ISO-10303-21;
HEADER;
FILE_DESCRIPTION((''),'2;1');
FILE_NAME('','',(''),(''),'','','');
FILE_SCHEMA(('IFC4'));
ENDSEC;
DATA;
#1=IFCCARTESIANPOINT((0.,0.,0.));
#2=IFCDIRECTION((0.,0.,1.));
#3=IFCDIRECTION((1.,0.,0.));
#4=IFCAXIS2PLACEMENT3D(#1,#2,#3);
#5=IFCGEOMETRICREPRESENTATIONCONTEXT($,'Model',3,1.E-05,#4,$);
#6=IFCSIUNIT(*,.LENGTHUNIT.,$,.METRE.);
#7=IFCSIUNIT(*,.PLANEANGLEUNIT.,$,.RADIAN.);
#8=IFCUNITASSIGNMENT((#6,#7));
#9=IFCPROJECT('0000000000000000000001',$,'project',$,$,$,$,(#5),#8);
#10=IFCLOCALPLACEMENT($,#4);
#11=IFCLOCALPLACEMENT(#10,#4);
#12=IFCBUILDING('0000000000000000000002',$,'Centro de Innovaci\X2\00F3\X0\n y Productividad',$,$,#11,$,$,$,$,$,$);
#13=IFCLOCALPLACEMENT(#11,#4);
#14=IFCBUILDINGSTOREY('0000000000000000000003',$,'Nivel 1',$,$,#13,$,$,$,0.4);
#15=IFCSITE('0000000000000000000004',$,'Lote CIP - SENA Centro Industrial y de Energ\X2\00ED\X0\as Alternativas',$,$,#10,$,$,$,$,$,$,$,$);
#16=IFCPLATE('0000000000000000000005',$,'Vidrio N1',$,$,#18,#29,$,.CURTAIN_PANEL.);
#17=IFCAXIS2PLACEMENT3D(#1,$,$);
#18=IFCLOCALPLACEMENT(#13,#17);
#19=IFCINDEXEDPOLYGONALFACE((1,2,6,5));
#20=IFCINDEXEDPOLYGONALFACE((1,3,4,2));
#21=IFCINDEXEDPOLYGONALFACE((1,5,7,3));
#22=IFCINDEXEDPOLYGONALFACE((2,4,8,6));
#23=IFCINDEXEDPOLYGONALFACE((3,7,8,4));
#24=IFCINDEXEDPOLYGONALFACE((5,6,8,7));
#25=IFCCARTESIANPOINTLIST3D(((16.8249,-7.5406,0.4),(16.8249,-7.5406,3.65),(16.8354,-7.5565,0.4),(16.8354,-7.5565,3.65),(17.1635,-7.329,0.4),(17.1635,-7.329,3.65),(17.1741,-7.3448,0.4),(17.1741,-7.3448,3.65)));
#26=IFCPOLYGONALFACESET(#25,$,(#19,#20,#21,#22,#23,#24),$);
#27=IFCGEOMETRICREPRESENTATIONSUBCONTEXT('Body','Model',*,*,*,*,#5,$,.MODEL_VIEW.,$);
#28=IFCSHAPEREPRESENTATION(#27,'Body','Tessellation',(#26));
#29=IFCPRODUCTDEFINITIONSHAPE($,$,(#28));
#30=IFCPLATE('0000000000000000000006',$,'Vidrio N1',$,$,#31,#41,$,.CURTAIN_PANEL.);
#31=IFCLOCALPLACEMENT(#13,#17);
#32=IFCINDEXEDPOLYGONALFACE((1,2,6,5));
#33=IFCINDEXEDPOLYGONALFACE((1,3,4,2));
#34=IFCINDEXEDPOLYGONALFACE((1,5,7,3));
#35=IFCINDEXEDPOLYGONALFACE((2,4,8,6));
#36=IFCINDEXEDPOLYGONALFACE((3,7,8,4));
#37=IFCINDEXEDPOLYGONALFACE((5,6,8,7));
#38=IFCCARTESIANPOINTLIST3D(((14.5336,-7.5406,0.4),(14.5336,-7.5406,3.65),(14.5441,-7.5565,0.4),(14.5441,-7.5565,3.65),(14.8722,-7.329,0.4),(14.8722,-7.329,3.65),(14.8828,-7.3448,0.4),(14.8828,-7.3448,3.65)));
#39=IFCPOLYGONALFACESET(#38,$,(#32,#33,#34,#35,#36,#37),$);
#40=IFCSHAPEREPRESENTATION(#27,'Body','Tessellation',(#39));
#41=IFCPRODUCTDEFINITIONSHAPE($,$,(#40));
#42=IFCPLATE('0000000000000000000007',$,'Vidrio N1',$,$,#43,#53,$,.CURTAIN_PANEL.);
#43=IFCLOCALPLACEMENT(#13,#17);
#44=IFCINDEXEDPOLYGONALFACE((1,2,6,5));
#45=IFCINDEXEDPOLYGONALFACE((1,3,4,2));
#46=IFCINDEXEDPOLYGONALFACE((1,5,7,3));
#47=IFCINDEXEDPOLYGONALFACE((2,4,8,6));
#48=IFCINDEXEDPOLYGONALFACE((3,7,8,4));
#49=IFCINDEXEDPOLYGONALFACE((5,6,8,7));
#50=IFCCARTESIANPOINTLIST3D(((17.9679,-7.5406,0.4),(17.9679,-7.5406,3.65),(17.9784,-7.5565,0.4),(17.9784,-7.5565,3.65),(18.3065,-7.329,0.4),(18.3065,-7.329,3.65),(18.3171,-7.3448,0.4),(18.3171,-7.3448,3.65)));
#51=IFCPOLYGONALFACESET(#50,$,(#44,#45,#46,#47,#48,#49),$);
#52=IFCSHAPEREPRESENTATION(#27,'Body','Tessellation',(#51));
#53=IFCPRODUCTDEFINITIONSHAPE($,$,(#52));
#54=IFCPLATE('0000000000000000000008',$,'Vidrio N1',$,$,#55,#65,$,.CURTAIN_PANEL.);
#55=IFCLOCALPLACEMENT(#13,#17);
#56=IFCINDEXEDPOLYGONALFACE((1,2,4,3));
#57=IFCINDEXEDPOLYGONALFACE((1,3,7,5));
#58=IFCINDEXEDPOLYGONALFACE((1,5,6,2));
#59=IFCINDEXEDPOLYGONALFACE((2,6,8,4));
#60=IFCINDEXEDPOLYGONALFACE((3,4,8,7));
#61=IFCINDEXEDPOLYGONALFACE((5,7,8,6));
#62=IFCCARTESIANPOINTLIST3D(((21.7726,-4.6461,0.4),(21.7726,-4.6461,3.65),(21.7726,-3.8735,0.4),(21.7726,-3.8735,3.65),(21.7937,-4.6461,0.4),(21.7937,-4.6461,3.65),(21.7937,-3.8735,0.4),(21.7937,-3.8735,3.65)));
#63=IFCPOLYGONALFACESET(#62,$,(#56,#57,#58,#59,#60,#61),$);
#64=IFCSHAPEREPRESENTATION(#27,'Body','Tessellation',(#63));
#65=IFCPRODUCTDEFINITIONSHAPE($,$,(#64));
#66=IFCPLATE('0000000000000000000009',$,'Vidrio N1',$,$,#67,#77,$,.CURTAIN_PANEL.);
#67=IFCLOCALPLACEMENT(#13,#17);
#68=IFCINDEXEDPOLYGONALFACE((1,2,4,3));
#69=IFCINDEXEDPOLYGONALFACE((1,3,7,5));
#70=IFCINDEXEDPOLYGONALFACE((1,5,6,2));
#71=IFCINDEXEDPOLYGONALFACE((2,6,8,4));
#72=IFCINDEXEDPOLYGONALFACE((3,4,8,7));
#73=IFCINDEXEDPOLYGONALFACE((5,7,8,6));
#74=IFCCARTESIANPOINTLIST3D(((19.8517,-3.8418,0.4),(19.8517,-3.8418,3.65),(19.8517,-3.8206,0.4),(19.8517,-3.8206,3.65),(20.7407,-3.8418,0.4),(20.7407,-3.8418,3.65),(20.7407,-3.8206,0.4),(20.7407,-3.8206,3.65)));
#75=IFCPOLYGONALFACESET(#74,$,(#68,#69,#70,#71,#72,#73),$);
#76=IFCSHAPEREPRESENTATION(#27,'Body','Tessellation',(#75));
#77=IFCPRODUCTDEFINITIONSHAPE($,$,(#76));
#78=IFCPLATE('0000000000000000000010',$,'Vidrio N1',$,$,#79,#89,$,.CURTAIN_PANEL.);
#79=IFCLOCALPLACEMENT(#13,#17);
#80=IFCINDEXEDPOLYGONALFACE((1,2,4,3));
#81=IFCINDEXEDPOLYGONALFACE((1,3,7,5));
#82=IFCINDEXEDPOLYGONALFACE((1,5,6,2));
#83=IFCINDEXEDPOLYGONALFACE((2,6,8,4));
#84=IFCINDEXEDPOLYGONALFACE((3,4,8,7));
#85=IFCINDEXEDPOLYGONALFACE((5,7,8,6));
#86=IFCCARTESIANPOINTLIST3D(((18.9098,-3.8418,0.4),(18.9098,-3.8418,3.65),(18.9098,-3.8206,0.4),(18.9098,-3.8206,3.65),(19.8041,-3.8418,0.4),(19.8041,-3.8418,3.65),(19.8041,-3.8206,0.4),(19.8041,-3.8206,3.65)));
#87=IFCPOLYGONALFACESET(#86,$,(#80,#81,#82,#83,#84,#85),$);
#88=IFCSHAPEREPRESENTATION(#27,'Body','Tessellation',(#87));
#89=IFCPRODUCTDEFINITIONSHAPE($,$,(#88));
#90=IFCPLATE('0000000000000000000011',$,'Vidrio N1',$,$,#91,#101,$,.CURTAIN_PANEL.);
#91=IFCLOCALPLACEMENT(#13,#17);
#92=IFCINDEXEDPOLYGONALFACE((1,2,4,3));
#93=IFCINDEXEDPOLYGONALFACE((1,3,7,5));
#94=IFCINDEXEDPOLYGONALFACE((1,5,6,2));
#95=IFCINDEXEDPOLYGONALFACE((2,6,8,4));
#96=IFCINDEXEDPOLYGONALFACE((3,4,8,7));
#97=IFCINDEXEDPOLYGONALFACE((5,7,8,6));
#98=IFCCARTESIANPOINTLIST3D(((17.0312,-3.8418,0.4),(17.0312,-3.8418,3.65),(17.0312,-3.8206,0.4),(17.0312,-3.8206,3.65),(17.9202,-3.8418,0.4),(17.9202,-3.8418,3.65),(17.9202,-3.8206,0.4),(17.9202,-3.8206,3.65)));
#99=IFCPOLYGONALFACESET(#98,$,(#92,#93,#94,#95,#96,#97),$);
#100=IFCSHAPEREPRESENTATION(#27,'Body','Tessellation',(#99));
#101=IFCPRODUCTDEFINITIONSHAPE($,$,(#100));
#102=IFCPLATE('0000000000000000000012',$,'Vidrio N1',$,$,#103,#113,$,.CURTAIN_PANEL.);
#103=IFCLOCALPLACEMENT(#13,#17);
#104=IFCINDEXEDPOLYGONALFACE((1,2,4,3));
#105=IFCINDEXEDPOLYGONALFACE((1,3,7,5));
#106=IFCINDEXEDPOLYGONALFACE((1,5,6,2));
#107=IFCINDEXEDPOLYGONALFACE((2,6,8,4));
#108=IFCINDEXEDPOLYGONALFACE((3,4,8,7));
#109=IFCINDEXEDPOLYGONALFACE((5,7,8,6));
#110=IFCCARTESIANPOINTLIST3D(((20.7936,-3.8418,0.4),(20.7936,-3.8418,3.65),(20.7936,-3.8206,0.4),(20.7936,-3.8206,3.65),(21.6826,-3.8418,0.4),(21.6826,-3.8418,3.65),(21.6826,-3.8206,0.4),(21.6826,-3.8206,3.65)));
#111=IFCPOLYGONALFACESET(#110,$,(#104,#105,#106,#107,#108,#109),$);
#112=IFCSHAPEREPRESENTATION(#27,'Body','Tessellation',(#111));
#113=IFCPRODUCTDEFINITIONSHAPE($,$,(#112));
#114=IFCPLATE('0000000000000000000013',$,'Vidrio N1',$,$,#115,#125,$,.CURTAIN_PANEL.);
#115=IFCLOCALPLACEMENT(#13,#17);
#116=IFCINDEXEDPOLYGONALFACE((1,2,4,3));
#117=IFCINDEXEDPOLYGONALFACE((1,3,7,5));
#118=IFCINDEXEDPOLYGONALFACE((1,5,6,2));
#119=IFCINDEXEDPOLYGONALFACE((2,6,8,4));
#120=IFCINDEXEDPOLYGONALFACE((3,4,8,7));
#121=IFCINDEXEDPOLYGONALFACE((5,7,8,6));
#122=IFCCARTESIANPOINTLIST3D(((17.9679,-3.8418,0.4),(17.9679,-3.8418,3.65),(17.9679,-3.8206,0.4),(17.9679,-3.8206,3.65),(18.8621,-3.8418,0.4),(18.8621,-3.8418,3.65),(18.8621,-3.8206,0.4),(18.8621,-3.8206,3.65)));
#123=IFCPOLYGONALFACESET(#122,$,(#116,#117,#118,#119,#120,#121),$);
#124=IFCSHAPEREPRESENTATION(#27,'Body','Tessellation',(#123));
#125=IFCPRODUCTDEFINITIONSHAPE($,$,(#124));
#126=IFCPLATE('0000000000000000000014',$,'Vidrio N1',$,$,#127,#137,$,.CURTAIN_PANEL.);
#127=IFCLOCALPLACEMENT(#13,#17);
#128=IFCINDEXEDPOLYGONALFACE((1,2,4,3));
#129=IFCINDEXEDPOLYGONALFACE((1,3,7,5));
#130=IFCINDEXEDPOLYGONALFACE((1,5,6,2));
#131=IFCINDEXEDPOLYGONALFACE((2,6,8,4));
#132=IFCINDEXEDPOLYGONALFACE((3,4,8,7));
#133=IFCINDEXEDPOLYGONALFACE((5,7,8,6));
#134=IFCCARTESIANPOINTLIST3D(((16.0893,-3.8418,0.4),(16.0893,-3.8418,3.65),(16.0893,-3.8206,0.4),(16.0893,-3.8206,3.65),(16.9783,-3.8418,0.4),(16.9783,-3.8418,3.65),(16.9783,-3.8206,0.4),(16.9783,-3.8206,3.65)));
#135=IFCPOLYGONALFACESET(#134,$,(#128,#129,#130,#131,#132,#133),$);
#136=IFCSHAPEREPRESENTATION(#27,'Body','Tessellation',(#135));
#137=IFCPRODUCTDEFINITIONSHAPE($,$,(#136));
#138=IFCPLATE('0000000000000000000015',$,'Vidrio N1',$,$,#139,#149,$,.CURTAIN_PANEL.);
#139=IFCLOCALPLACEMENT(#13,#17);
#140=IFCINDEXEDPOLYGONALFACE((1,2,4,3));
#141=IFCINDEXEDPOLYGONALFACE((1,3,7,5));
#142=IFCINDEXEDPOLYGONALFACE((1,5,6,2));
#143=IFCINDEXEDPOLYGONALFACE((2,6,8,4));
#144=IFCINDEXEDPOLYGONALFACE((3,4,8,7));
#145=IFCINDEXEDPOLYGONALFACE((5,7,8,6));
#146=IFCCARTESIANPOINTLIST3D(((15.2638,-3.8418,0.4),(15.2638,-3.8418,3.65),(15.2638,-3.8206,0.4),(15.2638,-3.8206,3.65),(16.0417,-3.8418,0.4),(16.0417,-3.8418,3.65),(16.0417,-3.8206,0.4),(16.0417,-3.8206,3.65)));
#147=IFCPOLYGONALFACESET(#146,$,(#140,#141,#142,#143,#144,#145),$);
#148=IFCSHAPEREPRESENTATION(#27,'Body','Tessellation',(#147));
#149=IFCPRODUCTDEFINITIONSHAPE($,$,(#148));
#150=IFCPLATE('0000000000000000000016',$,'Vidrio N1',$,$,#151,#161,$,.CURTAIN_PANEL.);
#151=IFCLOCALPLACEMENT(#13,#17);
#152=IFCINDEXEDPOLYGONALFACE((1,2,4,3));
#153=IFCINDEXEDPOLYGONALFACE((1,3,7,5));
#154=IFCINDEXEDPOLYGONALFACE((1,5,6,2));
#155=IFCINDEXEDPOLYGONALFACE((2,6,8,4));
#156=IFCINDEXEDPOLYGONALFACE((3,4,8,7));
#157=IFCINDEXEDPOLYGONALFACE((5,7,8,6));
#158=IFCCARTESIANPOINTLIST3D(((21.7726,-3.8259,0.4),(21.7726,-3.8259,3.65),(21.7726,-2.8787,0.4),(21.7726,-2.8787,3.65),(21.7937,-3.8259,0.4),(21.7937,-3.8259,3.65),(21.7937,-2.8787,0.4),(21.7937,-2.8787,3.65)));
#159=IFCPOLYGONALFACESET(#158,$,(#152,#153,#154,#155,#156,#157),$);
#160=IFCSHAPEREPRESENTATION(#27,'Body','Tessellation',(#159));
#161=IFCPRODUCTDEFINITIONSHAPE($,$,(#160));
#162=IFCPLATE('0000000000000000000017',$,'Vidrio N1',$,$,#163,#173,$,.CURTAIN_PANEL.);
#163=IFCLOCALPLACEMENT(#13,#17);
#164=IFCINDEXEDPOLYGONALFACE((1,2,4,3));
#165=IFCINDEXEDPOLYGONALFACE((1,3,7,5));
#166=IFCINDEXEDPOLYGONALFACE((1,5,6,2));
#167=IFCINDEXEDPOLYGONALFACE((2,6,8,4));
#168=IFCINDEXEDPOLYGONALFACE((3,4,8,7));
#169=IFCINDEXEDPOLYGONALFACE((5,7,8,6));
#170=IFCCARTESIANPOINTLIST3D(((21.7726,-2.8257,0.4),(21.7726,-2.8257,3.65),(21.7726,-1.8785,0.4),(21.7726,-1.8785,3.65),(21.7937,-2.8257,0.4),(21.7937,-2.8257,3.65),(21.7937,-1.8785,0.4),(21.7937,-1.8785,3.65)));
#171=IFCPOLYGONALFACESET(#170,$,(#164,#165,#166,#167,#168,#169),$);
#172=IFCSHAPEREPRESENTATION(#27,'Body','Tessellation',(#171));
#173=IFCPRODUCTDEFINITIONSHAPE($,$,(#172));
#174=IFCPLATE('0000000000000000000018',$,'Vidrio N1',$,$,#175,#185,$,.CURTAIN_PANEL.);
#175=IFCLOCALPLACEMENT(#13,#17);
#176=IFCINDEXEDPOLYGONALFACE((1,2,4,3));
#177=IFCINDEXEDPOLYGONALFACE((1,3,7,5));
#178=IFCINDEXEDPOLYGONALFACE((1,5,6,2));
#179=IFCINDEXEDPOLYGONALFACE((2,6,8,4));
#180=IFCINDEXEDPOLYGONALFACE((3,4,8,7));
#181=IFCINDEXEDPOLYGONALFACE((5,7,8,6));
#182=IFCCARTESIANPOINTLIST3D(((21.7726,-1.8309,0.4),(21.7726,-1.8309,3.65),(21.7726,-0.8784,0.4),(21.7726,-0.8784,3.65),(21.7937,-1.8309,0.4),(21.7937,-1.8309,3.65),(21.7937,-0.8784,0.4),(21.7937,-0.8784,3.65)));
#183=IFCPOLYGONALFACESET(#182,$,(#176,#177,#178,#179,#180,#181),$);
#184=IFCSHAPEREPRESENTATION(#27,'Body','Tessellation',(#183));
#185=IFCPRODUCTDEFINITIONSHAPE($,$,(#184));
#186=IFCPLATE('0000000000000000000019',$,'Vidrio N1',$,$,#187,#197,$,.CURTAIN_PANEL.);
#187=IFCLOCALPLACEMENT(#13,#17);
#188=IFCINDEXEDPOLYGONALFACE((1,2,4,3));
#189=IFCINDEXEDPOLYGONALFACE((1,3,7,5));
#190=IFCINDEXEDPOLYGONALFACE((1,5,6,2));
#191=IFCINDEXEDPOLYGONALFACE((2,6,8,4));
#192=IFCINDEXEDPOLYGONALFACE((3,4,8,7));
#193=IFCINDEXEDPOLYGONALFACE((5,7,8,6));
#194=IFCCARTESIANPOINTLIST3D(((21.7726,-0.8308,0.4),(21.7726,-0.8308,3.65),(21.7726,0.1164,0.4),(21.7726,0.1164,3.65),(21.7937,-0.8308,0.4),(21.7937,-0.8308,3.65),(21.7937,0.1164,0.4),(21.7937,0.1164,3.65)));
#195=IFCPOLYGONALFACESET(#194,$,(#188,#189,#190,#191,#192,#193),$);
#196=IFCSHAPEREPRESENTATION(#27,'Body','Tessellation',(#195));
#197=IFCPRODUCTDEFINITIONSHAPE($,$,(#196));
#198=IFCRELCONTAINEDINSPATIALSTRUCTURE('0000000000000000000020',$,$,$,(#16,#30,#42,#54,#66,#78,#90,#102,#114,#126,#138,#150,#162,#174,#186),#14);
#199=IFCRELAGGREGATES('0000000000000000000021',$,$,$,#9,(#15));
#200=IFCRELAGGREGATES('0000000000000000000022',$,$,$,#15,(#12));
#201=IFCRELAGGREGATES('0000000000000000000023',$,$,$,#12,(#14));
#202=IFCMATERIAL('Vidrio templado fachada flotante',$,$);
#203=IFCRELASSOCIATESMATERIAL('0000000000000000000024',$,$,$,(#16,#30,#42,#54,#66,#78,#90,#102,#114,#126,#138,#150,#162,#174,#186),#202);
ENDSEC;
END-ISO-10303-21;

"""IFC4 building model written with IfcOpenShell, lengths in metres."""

from ifc_helpers import new_model, si_unit, frame, origin_with_axes, place, context, subcontext, project, spatial, polyline, outline, extrude, material, element, save


model = new_model("IFC4")

# Units and contexts
model_context = context("Model", 3, precision=1e-05, world=origin_with_axes())
body_context = subcontext(model_context, "Body", "Model", "MODEL_VIEW")
ifc_project = project(units=[si_unit("LENGTHUNIT", "METRE"), si_unit("PLANEANGLEUNIT", "RADIAN")], contexts=[model_context])

# Site, building, storey
site_placement = place(None, origin_with_axes())
site = spatial("IfcSite", under=ifc_project, at=site_placement, Name="Lote CIP - SENA Centro Industrial y de Energías Alternativas")
building_placement = place(site_placement, origin_with_axes())
building = spatial("IfcBuilding", under=site, at=building_placement, Name="Centro de Innovación y Productividad")
storey_placement = place(building_placement, origin_with_axes())
storey = spatial("IfcBuildingStorey", under=building, at=storey_placement, Name="Nivel 1", Elevation=0.4)

# Plates
ifc_material = material(Name="Vidrio templado fachada flotante")
plate_1_placement = place(storey_placement, origin_with_axes())
element("IfcPlate", 1, at=plate_1_placement, inside=storey, material=ifc_material, Name="Vidrio N1", PredefinedType="CURTAIN_PANEL", context=body_context, shape_type="SweptSolid", body=[
    extrude(outline(polyline([(17.1635, -7.329), (17.1741, -7.3448), (16.8354, -7.5565), (16.8249, -7.5406), (17.1635, -7.329)])), frame((0.0, 0.0, 0.4)), (0.0, 0.0, 1.0), 3.25),
])
plate_2_placement = place(storey_placement, origin_with_axes())
element("IfcPlate", 2, at=plate_2_placement, inside=storey, material=ifc_material, Name="Vidrio N1", PredefinedType="CURTAIN_PANEL", context=body_context, shape_type="SweptSolid", body=[
    extrude(outline(polyline([(14.8722, -7.329), (14.8828, -7.3448), (14.5441, -7.5565), (14.5336, -7.5406), (14.8722, -7.329)])), frame((0.0, 0.0, 0.4)), (0.0, 0.0, 1.0), 3.25),
])
plate_3_placement = place(storey_placement, origin_with_axes())
element("IfcPlate", 3, at=plate_3_placement, inside=storey, material=ifc_material, Name="Vidrio N1", PredefinedType="CURTAIN_PANEL", context=body_context, shape_type="SweptSolid", body=[
    extrude(outline(polyline([(18.3065, -7.329), (18.3171, -7.3448), (17.9784, -7.5565), (17.9679, -7.5406), (18.3065, -7.329)])), frame((0.0, 0.0, 0.4)), (0.0, 0.0, 1.0), 3.25),
])
plate_4_placement = place(storey_placement, origin_with_axes())
element("IfcPlate", 4, at=plate_4_placement, inside=storey, material=ifc_material, Name="Vidrio N1", PredefinedType="CURTAIN_PANEL", context=body_context, shape_type="SweptSolid", body=[
    extrude(outline(polyline([(21.7726, -3.8735), (21.7937, -3.8735), (21.7937, -4.6461), (21.7726, -4.6461), (21.7726, -3.8735)])), frame((0.0, 0.0, 0.4)), (0.0, 0.0, 1.0), 3.25),
])
plate_5_placement = place(storey_placement, origin_with_axes())
element("IfcPlate", 5, at=plate_5_placement, inside=storey, material=ifc_material, Name="Vidrio N1", PredefinedType="CURTAIN_PANEL", context=body_context, shape_type="SweptSolid", body=[
    extrude(outline(polyline([(20.7407, -3.8206), (20.7407, -3.8417), (19.8517, -3.8417), (19.8517, -3.8206), (20.7407, -3.8206)])), frame((0.0, 0.0, 0.4)), (0.0, 0.0, 1.0), 3.25),
])
plate_6_placement = place(storey_placement, origin_with_axes())
element("IfcPlate", 6, at=plate_6_placement, inside=storey, material=ifc_material, Name="Vidrio N1", PredefinedType="CURTAIN_PANEL", context=body_context, shape_type="SweptSolid", body=[
    extrude(outline(polyline([(18.9098, -3.8417), (18.9098, -3.8206), (19.8041, -3.8206), (19.8041, -3.8417), (18.9098, -3.8417)])), frame((0.0, 0.0, 0.4)), (0.0, 0.0, 1.0), 3.25),
])
plate_7_placement = place(storey_placement, origin_with_axes())
element("IfcPlate", 7, at=plate_7_placement, inside=storey, material=ifc_material, Name="Vidrio N1", PredefinedType="CURTAIN_PANEL", context=body_context, shape_type="SweptSolid", body=[
    extrude(outline(polyline([(17.0312, -3.8417), (17.0312, -3.8206), (17.9202, -3.8206), (17.9202, -3.8417), (17.0312, -3.8417)])), frame((0.0, 0.0, 0.4)), (0.0, 0.0, 1.0), 3.25),
])
plate_8_placement = place(storey_placement, origin_with_axes())
element("IfcPlate", 8, at=plate_8_placement, inside=storey, material=ifc_material, Name="Vidrio N1", PredefinedType="CURTAIN_PANEL", context=body_context, shape_type="SweptSolid", body=[
    extrude(outline(polyline([(21.6826, -3.8417), (20.7936, -3.8417), (20.7936, -3.8206), (21.6826, -3.8206), (21.6826, -3.8417)])), frame((0.0, 0.0, 0.4)), (0.0, 0.0, 1.0), 3.25),
])
plate_9_placement = place(storey_placement, origin_with_axes())
element("IfcPlate", 9, at=plate_9_placement, inside=storey, material=ifc_material, Name="Vidrio N1", PredefinedType="CURTAIN_PANEL", context=body_context, shape_type="SweptSolid", body=[
    extrude(outline(polyline([(18.8621, -3.8417), (17.9679, -3.8417), (17.9679, -3.8206), (18.8621, -3.8206), (18.8621, -3.8417)])), frame((0.0, 0.0, 0.4)), (0.0, 0.0, 1.0), 3.25),
])
plate_10_placement = place(storey_placement, origin_with_axes())
element("IfcPlate", 10, at=plate_10_placement, inside=storey, material=ifc_material, Name="Vidrio N1", PredefinedType="CURTAIN_PANEL", context=body_context, shape_type="SweptSolid", body=[
    extrude(outline(polyline([(16.9783, -3.8417), (16.0893, -3.8417), (16.0893, -3.8206), (16.9783, -3.8206), (16.9783, -3.8417)])), frame((0.0, 0.0, 0.4)), (0.0, 0.0, 1.0), 3.25),
])
plate_11_placement = place(storey_placement, origin_with_axes())
element("IfcPlate", 11, at=plate_11_placement, inside=storey, material=ifc_material, Name="Vidrio N1", PredefinedType="CURTAIN_PANEL", context=body_context, shape_type="SweptSolid", body=[
    extrude(outline(polyline([(15.2638, -3.8417), (15.2638, -3.8206), (16.0417, -3.8206), (16.0417, -3.8417), (15.2638, -3.8417)])), frame((0.0, 0.0, 0.4)), (0.0, 0.0, 1.0), 3.25),
])
plate_12_placement = place(storey_placement, origin_with_axes())
element("IfcPlate", 12, at=plate_12_placement, inside=storey, material=ifc_material, Name="Vidrio N1", PredefinedType="CURTAIN_PANEL", context=body_context, shape_type="SweptSolid", body=[
    extrude(outline(polyline([(21.7726, -2.8787), (21.7937, -2.8787), (21.7937, -3.8259), (21.7726, -3.8259), (21.7726, -2.8787)])), frame((0.0, 0.0, 0.4)), (0.0, 0.0, 1.0), 3.25),
])
plate_13_placement = place(storey_placement, origin_with_axes())
element("IfcPlate", 13, at=plate_13_placement, inside=storey, material=ifc_material, Name="Vidrio N1", PredefinedType="CURTAIN_PANEL", context=body_context, shape_type="SweptSolid", body=[
    extrude(outline(polyline([(21.7726, -2.8257), (21.7726, -1.8785), (21.7937, -1.8785), (21.7937, -2.8257), (21.7726, -2.8257)])), frame((0.0, 0.0, 0.4)), (0.0, 0.0, 1.0), 3.25),
])
plate_14_placement = place(storey_placement, origin_with_axes())
element("IfcPlate", 14, at=plate_14_placement, inside=storey, material=ifc_material, Name="Vidrio N1", PredefinedType="CURTAIN_PANEL", context=body_context, shape_type="SweptSolid", body=[
    extrude(outline(polyline([(21.7726, -1.8309), (21.7726, -0.8784), (21.7937, -0.8784), (21.7937, -1.8309), (21.7726, -1.8309)])), frame((0.0, 0.0, 0.4)), (0.0, 0.0, 1.0), 3.25),
])
plate_15_placement = place(storey_placement, origin_with_axes())
element("IfcPlate", 15, at=plate_15_placement, inside=storey, material=ifc_material, Name="Vidrio N1", PredefinedType="CURTAIN_PANEL", context=body_context, shape_type="SweptSolid", body=[
    extrude(outline(polyline([(21.7937, -0.8308), (21.7726, -0.8308), (21.7726, 0.1164), (21.7937, 0.1164), (21.7937, -0.8308)])), frame((0.0, 0.0, 0.4)), (0.0, 0.0, 1.0), 3.25),
])

save(model, "model.ifc")
